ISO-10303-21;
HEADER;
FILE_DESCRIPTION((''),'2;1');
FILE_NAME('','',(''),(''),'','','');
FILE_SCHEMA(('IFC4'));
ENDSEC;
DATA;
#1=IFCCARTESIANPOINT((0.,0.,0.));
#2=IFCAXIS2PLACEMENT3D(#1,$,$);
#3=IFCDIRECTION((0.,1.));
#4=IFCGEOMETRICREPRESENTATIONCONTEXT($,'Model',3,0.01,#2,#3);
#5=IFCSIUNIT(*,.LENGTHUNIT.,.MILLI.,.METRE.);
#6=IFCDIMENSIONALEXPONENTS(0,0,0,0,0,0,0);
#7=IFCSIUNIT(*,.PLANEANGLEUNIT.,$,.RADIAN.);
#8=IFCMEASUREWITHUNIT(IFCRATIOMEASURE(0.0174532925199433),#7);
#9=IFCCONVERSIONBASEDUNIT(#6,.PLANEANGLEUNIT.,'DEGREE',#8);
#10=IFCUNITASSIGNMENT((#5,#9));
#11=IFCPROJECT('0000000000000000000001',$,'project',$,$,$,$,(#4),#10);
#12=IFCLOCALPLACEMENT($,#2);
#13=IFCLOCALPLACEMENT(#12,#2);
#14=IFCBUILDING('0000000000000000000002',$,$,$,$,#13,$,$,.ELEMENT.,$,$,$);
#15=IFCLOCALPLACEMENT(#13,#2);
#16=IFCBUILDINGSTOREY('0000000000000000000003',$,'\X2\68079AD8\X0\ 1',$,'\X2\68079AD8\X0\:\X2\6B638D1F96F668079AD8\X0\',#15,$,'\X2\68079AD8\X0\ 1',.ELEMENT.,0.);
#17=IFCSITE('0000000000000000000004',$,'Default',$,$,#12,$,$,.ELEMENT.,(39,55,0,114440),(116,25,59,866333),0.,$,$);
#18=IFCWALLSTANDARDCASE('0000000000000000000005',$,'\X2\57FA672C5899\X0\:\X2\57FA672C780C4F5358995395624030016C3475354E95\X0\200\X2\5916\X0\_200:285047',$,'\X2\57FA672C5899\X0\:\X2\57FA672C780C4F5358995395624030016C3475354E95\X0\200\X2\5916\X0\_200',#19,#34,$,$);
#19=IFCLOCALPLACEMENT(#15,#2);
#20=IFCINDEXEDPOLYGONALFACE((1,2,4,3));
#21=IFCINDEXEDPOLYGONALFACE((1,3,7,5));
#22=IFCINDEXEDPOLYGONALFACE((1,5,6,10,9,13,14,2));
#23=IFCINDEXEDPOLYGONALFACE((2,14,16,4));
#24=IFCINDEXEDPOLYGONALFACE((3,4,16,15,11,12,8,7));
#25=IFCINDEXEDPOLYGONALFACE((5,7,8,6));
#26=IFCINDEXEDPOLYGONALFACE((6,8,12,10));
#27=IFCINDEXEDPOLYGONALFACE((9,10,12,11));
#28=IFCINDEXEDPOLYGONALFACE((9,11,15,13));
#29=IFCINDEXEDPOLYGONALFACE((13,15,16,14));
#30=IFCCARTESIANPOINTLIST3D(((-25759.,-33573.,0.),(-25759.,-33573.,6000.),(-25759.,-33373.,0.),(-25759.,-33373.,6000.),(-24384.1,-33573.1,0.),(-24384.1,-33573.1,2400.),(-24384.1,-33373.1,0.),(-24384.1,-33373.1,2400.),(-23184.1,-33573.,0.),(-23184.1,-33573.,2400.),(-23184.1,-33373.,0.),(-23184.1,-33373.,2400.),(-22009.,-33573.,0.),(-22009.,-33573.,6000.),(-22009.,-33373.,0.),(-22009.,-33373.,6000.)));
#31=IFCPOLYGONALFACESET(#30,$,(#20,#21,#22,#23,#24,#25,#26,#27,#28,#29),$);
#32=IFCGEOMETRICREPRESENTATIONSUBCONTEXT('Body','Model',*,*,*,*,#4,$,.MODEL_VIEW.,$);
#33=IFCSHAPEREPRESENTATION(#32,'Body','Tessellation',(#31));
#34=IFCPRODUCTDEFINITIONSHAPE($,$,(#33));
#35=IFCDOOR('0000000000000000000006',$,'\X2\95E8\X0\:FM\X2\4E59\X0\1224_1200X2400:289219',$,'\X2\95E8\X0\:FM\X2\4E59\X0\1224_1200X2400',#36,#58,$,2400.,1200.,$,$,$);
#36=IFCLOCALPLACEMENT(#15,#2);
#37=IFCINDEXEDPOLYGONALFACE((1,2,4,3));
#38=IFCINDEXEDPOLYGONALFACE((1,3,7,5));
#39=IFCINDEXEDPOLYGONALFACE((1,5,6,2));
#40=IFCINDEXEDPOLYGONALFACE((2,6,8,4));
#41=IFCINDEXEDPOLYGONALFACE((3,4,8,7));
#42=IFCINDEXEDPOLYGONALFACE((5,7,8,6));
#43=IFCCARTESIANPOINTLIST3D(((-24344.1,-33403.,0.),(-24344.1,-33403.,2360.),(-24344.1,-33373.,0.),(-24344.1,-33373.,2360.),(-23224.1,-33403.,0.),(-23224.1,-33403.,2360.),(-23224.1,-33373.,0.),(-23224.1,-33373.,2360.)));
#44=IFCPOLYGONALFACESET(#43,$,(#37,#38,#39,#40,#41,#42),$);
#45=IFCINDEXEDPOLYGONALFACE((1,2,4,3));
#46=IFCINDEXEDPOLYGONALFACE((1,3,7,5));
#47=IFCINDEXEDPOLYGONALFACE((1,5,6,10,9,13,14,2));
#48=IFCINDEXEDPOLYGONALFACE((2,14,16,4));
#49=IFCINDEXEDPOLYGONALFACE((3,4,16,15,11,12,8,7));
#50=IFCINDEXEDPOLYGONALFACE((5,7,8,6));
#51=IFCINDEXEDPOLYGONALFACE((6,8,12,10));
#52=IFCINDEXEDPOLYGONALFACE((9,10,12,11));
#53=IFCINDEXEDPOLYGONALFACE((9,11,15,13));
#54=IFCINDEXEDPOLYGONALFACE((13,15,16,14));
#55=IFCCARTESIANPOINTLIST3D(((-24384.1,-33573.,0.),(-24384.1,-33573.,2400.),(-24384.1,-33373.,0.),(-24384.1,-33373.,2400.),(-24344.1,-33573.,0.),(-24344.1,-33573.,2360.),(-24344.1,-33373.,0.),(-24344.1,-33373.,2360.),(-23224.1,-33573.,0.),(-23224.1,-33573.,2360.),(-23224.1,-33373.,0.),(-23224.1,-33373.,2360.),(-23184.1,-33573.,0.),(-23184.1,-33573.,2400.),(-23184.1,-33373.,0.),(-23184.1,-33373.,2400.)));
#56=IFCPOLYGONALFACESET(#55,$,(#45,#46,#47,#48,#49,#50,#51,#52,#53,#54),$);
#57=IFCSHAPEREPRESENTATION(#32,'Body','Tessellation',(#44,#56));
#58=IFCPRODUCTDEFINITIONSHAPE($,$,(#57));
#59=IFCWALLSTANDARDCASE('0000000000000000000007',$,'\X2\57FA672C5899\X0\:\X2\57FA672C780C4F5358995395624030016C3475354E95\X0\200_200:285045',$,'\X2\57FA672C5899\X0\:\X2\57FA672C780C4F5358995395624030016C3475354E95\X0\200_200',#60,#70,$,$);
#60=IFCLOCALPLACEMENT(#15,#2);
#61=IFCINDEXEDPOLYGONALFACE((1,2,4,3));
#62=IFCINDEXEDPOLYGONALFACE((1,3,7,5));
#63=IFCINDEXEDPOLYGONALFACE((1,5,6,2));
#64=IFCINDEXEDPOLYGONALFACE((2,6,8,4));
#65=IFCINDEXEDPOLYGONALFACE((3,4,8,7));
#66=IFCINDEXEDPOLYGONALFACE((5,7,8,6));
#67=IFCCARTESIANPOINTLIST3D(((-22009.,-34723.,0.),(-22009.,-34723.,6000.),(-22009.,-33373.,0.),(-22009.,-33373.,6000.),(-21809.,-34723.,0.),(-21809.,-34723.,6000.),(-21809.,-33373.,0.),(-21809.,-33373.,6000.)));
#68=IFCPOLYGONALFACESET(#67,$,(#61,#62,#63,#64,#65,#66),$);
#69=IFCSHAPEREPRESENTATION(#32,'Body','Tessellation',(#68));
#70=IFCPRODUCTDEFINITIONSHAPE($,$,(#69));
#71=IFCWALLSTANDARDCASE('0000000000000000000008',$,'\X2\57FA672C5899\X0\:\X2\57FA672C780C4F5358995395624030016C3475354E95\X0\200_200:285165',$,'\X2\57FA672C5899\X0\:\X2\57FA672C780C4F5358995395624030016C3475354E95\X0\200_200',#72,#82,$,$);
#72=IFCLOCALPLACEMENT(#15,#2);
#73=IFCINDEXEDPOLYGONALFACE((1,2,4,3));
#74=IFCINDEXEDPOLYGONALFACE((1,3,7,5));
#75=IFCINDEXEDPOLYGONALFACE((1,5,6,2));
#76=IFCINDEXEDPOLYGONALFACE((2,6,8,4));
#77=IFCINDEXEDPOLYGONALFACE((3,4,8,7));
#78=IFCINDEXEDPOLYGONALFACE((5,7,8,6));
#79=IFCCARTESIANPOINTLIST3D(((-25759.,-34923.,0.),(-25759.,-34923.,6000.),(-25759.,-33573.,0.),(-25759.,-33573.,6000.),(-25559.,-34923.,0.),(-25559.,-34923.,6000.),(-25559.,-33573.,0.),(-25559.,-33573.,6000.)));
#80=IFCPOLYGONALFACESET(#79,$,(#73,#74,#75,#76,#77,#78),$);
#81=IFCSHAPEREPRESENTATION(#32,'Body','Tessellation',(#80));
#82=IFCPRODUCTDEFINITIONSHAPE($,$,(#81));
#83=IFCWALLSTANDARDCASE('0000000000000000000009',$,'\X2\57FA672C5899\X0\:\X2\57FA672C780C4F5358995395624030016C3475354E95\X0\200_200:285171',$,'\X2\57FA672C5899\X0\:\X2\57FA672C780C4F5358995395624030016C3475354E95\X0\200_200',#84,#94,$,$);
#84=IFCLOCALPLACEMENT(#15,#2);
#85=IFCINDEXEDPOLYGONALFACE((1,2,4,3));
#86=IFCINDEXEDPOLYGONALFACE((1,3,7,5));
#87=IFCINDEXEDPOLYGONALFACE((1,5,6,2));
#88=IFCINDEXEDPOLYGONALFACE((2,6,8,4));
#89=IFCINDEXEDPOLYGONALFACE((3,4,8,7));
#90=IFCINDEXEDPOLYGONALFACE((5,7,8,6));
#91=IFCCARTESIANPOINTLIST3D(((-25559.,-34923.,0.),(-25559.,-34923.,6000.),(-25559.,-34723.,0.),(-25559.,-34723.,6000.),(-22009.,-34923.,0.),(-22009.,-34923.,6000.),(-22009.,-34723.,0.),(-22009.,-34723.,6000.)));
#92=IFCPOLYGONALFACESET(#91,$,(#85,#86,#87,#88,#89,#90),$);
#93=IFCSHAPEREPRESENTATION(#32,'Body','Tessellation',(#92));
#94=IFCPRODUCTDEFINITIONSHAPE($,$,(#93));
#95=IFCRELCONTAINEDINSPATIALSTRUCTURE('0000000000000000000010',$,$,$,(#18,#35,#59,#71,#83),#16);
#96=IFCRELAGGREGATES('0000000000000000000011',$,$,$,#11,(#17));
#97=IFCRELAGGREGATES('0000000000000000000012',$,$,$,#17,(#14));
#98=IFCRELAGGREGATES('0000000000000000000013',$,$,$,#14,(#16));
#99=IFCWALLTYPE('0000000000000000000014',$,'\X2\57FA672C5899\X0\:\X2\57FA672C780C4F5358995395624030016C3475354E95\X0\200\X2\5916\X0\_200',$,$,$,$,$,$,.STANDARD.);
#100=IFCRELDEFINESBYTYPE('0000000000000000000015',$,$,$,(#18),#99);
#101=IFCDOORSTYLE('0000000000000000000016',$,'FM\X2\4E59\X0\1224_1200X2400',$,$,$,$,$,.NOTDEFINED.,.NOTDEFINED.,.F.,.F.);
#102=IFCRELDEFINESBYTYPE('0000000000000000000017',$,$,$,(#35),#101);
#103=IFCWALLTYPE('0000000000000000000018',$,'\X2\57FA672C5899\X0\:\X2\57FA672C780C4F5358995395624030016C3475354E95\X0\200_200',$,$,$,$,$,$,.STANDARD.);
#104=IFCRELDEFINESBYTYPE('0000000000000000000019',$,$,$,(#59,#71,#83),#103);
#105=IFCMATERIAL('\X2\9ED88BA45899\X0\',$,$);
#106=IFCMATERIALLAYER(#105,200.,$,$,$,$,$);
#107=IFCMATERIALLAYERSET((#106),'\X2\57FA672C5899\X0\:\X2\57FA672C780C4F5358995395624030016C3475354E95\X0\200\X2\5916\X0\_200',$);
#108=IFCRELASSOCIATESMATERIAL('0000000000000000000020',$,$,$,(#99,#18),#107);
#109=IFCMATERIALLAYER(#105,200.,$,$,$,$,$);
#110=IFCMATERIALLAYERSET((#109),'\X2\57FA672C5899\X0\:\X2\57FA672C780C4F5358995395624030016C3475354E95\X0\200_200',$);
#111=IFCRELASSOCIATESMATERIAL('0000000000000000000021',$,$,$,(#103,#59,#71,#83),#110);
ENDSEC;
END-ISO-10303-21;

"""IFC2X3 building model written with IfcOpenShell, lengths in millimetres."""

from ifc_helpers import new_model, entity, si_unit, converted_unit, direction, frame, frame_2d, origin, place, context, subcontext, project, spatial, polyline, rectangle, outline, extrude, source, transform, mapped, material, layer, layer_set, layer_usage, type_object, type_shapes, element, fill, save


model = new_model("IFC2X3")

# Units and contexts
model_context = context("Model", 3, precision=0.01, world=origin(), true_north=direction((0.0, 1.0)))
body_context = subcontext(model_context, "Body", "Model", "MODEL_VIEW")
ifc_project = project(units=[si_unit("LENGTHUNIT", "METRE", prefix="MILLI"), converted_unit("PLANEANGLEUNIT", "DEGREE", entity("IfcRatioMeasure", 0.0174532925199433), si_unit("PLANEANGLEUNIT", "RADIAN"), dimensions=[0, 0, 0, 0, 0, 0, 0])], contexts=[model_context])

# Site, building, storey
site_placement = place(None, origin())
site = spatial("IfcSite", under=ifc_project, at=site_placement, Name="Default", CompositionType="ELEMENT", RefLatitude=(39, 55, 0, 114440), RefLongitude=(116, 25, 59, 866333), RefElevation=0.0)
building_placement = place(site_placement, origin())
building = spatial("IfcBuilding", under=site, at=building_placement, CompositionType="ELEMENT")
storey_placement = place(building_placement, origin())
storey = spatial("IfcBuildingStorey", under=building, at=storey_placement, Name="标高 1", ObjectType="标高:正负零标高", LongName="标高 1", CompositionType="ELEMENT", Elevation=0.0)

# Shared definitions
ifc_material = material(Name="默认墙")

# Wall, opening, door
ifc_layer_1 = layer(ifc_material, 200.0)
ifc_layer_set_1 = layer_set([ifc_layer_1], Name="基本墙:基本砌体墙厕所、水电井200外_200")
ifc_layer_usage_1 = layer_usage(ifc_layer_set_1, "AXIS2", "NEGATIVE", 100.0)
wall_type_1 = type_object("IfcWallType", Name="基本墙:基本砌体墙厕所、水电井200外_200", PredefinedType="STANDARD", material=ifc_layer_set_1)
wall_1_placement = place(building_placement, frame((-25759.0, -33473.0, 0.0)))
wall_1 = element("IfcWallStandardCase", 1, at=wall_1_placement, inside=storey, type_object=wall_type_1, material=ifc_layer_usage_1, Name="基本墙:基本砌体墙厕所、水电井200外_200:285047", ObjectType="基本墙:基本砌体墙厕所、水电井200外_200", context=body_context, shape_type="SweptSolid", body=[
    extrude(rectangle(XDim=3750.0, YDim=200.0, at=frame_2d((1875.0, 0.0), x_axis=(-1.0, 0.0))), origin(), (0.0, 0.0, 1.0), 6000.0),
])
opening_placement = place(wall_1_placement, frame((1374.9, -100.0, 0.0)))
opening = element("IfcOpeningElement", 2, at=opening_placement, cuts=wall_1, ObjectType="Opening", context=body_context, shape_type="SweptSolid", body=[
    extrude(rectangle(XDim=2400.0, YDim=1200.0, at=frame_2d((1200.0, 600.0), x_axis=(1.0, 0.0))), frame((0.0, 0.0, 0.0), z_axis=(-0.000011, 1.0, 0.0), x_axis=(0.0, 0.0, 1.0)), (0.0, 0.0, 1.0), 200.0),
])
door_style = type_object("IfcDoorStyle", Name="FM乙1224_1200X2400", ConstructionType="NOTDEFINED", OperationType="NOTDEFINED", ParameterTakesPrecedence=False, Sizeable=False)
shared_shape_1 = source(origin(), body_context, "Body", "SweptSolid", [
    extrude(rectangle(XDim=30.0, YDim=1120.0, at=frame_2d((0.0, 0.0), x_axis=(1.0, 0.0))), frame((600.0, -715.0, 0.0), z_axis=(0.0, 0.0, 1.0), x_axis=(0.0, 1.0, 0.0)), (0.0, 0.0, 1.0), 2360.0),
    extrude(outline(polyline([(-1170.0, 560.0), (1190.0, 560.0), (1190.0, 600.0), (-1210.0, 600.0), (-1210.0, -600.0), (1190.0, -600.0), (1190.0, -560.0), (-1170.0, -560.0), (-1170.0, 560.0)])), frame((600.0, -900.0, 1190.0), z_axis=(0.0, 1.0, 0.0), x_axis=(0.0, 0.0, -1.0)), (0.0, 0.0, 1.0), 200.0),
])
type_shapes(door_style, [shared_shape_1])
door_placement = place(opening_placement, frame((0.0, 900.0, 0.0)))
door = element("IfcDoor", 3, at=door_placement, inside=storey, type_object=door_style, Name="门:FM乙1224_1200X2400:289219", ObjectType="门:FM乙1224_1200X2400", OverallHeight=2400.0, OverallWidth=1200.0, context=body_context, shape_type="MappedRepresentation", body=[
    mapped(shared_shape_1, transform((0.0, 0.0, 0.0), scale=1.0)),
])
fill(opening, door)

# Walls
ifc_layer_2 = layer(ifc_material, 200.0)
ifc_layer_set_2 = layer_set([ifc_layer_2], Name="基本墙:基本砌体墙厕所、水电井200_200")
ifc_layer_usage_2 = layer_usage(ifc_layer_set_2, "AXIS2", "NEGATIVE", 100.0)
wall_type_2 = type_object("IfcWallType", Name="基本墙:基本砌体墙厕所、水电井200_200", PredefinedType="STANDARD", material=ifc_layer_set_2)
wall_2_placement = place(building_placement, frame((-21909.0, -34723.0, 0.0), z_axis=(0.0, 0.0, 1.0), x_axis=(0.0, 1.0, 0.0)))
element("IfcWallStandardCase", 4, at=wall_2_placement, inside=storey, type_object=wall_type_2, material=ifc_layer_usage_2, Name="基本墙:基本砌体墙厕所、水电井200_200:285045", ObjectType="基本墙:基本砌体墙厕所、水电井200_200", context=body_context, shape_type="SweptSolid", body=[
    extrude(rectangle(XDim=1350.0, YDim=200.0, at=frame_2d((675.0, 0.0), x_axis=(-1.0, 0.0))), origin(), (0.0, 0.0, 1.0), 6000.0),
])
ifc_layer_usage_3 = layer_usage(ifc_layer_set_2, "AXIS2", "NEGATIVE", 100.0)
wall_3_placement = place(building_placement, frame((-25659.0, -34923.0, 0.0), z_axis=(0.0, 0.0, 1.0), x_axis=(0.0, 1.0, 0.0)))
element("IfcWallStandardCase", 5, at=wall_3_placement, inside=storey, type_object=wall_type_2, material=ifc_layer_usage_3, Name="基本墙:基本砌体墙厕所、水电井200_200:285165", ObjectType="基本墙:基本砌体墙厕所、水电井200_200", context=body_context, shape_type="SweptSolid", body=[
    extrude(rectangle(XDim=1350.0, YDim=200.0, at=frame_2d((675.0, 0.0), x_axis=(-1.0, 0.0))), origin(), (0.0, 0.0, 1.0), 6000.0),
])
ifc_layer_usage_4 = layer_usage(ifc_layer_set_2, "AXIS2", "NEGATIVE", 100.0)
wall_4_placement = place(building_placement, frame((-22009.0, -34823.0, 0.0), z_axis=(0.0, 0.0, 1.0), x_axis=(-1.0, 0.0, 0.0)))
element("IfcWallStandardCase", 6, at=wall_4_placement, inside=storey, type_object=wall_type_2, material=ifc_layer_usage_4, Name="基本墙:基本砌体墙厕所、水电井200_200:285171", ObjectType="基本墙:基本砌体墙厕所、水电井200_200", context=body_context, shape_type="SweptSolid", body=[
    extrude(rectangle(XDim=3550.0, YDim=200.0, at=frame_2d((1775.0, 0.0), x_axis=(-1.0, 0.0))), origin(), (0.0, 0.0, 1.0), 6000.0),
])

save(model, "model.ifc")
